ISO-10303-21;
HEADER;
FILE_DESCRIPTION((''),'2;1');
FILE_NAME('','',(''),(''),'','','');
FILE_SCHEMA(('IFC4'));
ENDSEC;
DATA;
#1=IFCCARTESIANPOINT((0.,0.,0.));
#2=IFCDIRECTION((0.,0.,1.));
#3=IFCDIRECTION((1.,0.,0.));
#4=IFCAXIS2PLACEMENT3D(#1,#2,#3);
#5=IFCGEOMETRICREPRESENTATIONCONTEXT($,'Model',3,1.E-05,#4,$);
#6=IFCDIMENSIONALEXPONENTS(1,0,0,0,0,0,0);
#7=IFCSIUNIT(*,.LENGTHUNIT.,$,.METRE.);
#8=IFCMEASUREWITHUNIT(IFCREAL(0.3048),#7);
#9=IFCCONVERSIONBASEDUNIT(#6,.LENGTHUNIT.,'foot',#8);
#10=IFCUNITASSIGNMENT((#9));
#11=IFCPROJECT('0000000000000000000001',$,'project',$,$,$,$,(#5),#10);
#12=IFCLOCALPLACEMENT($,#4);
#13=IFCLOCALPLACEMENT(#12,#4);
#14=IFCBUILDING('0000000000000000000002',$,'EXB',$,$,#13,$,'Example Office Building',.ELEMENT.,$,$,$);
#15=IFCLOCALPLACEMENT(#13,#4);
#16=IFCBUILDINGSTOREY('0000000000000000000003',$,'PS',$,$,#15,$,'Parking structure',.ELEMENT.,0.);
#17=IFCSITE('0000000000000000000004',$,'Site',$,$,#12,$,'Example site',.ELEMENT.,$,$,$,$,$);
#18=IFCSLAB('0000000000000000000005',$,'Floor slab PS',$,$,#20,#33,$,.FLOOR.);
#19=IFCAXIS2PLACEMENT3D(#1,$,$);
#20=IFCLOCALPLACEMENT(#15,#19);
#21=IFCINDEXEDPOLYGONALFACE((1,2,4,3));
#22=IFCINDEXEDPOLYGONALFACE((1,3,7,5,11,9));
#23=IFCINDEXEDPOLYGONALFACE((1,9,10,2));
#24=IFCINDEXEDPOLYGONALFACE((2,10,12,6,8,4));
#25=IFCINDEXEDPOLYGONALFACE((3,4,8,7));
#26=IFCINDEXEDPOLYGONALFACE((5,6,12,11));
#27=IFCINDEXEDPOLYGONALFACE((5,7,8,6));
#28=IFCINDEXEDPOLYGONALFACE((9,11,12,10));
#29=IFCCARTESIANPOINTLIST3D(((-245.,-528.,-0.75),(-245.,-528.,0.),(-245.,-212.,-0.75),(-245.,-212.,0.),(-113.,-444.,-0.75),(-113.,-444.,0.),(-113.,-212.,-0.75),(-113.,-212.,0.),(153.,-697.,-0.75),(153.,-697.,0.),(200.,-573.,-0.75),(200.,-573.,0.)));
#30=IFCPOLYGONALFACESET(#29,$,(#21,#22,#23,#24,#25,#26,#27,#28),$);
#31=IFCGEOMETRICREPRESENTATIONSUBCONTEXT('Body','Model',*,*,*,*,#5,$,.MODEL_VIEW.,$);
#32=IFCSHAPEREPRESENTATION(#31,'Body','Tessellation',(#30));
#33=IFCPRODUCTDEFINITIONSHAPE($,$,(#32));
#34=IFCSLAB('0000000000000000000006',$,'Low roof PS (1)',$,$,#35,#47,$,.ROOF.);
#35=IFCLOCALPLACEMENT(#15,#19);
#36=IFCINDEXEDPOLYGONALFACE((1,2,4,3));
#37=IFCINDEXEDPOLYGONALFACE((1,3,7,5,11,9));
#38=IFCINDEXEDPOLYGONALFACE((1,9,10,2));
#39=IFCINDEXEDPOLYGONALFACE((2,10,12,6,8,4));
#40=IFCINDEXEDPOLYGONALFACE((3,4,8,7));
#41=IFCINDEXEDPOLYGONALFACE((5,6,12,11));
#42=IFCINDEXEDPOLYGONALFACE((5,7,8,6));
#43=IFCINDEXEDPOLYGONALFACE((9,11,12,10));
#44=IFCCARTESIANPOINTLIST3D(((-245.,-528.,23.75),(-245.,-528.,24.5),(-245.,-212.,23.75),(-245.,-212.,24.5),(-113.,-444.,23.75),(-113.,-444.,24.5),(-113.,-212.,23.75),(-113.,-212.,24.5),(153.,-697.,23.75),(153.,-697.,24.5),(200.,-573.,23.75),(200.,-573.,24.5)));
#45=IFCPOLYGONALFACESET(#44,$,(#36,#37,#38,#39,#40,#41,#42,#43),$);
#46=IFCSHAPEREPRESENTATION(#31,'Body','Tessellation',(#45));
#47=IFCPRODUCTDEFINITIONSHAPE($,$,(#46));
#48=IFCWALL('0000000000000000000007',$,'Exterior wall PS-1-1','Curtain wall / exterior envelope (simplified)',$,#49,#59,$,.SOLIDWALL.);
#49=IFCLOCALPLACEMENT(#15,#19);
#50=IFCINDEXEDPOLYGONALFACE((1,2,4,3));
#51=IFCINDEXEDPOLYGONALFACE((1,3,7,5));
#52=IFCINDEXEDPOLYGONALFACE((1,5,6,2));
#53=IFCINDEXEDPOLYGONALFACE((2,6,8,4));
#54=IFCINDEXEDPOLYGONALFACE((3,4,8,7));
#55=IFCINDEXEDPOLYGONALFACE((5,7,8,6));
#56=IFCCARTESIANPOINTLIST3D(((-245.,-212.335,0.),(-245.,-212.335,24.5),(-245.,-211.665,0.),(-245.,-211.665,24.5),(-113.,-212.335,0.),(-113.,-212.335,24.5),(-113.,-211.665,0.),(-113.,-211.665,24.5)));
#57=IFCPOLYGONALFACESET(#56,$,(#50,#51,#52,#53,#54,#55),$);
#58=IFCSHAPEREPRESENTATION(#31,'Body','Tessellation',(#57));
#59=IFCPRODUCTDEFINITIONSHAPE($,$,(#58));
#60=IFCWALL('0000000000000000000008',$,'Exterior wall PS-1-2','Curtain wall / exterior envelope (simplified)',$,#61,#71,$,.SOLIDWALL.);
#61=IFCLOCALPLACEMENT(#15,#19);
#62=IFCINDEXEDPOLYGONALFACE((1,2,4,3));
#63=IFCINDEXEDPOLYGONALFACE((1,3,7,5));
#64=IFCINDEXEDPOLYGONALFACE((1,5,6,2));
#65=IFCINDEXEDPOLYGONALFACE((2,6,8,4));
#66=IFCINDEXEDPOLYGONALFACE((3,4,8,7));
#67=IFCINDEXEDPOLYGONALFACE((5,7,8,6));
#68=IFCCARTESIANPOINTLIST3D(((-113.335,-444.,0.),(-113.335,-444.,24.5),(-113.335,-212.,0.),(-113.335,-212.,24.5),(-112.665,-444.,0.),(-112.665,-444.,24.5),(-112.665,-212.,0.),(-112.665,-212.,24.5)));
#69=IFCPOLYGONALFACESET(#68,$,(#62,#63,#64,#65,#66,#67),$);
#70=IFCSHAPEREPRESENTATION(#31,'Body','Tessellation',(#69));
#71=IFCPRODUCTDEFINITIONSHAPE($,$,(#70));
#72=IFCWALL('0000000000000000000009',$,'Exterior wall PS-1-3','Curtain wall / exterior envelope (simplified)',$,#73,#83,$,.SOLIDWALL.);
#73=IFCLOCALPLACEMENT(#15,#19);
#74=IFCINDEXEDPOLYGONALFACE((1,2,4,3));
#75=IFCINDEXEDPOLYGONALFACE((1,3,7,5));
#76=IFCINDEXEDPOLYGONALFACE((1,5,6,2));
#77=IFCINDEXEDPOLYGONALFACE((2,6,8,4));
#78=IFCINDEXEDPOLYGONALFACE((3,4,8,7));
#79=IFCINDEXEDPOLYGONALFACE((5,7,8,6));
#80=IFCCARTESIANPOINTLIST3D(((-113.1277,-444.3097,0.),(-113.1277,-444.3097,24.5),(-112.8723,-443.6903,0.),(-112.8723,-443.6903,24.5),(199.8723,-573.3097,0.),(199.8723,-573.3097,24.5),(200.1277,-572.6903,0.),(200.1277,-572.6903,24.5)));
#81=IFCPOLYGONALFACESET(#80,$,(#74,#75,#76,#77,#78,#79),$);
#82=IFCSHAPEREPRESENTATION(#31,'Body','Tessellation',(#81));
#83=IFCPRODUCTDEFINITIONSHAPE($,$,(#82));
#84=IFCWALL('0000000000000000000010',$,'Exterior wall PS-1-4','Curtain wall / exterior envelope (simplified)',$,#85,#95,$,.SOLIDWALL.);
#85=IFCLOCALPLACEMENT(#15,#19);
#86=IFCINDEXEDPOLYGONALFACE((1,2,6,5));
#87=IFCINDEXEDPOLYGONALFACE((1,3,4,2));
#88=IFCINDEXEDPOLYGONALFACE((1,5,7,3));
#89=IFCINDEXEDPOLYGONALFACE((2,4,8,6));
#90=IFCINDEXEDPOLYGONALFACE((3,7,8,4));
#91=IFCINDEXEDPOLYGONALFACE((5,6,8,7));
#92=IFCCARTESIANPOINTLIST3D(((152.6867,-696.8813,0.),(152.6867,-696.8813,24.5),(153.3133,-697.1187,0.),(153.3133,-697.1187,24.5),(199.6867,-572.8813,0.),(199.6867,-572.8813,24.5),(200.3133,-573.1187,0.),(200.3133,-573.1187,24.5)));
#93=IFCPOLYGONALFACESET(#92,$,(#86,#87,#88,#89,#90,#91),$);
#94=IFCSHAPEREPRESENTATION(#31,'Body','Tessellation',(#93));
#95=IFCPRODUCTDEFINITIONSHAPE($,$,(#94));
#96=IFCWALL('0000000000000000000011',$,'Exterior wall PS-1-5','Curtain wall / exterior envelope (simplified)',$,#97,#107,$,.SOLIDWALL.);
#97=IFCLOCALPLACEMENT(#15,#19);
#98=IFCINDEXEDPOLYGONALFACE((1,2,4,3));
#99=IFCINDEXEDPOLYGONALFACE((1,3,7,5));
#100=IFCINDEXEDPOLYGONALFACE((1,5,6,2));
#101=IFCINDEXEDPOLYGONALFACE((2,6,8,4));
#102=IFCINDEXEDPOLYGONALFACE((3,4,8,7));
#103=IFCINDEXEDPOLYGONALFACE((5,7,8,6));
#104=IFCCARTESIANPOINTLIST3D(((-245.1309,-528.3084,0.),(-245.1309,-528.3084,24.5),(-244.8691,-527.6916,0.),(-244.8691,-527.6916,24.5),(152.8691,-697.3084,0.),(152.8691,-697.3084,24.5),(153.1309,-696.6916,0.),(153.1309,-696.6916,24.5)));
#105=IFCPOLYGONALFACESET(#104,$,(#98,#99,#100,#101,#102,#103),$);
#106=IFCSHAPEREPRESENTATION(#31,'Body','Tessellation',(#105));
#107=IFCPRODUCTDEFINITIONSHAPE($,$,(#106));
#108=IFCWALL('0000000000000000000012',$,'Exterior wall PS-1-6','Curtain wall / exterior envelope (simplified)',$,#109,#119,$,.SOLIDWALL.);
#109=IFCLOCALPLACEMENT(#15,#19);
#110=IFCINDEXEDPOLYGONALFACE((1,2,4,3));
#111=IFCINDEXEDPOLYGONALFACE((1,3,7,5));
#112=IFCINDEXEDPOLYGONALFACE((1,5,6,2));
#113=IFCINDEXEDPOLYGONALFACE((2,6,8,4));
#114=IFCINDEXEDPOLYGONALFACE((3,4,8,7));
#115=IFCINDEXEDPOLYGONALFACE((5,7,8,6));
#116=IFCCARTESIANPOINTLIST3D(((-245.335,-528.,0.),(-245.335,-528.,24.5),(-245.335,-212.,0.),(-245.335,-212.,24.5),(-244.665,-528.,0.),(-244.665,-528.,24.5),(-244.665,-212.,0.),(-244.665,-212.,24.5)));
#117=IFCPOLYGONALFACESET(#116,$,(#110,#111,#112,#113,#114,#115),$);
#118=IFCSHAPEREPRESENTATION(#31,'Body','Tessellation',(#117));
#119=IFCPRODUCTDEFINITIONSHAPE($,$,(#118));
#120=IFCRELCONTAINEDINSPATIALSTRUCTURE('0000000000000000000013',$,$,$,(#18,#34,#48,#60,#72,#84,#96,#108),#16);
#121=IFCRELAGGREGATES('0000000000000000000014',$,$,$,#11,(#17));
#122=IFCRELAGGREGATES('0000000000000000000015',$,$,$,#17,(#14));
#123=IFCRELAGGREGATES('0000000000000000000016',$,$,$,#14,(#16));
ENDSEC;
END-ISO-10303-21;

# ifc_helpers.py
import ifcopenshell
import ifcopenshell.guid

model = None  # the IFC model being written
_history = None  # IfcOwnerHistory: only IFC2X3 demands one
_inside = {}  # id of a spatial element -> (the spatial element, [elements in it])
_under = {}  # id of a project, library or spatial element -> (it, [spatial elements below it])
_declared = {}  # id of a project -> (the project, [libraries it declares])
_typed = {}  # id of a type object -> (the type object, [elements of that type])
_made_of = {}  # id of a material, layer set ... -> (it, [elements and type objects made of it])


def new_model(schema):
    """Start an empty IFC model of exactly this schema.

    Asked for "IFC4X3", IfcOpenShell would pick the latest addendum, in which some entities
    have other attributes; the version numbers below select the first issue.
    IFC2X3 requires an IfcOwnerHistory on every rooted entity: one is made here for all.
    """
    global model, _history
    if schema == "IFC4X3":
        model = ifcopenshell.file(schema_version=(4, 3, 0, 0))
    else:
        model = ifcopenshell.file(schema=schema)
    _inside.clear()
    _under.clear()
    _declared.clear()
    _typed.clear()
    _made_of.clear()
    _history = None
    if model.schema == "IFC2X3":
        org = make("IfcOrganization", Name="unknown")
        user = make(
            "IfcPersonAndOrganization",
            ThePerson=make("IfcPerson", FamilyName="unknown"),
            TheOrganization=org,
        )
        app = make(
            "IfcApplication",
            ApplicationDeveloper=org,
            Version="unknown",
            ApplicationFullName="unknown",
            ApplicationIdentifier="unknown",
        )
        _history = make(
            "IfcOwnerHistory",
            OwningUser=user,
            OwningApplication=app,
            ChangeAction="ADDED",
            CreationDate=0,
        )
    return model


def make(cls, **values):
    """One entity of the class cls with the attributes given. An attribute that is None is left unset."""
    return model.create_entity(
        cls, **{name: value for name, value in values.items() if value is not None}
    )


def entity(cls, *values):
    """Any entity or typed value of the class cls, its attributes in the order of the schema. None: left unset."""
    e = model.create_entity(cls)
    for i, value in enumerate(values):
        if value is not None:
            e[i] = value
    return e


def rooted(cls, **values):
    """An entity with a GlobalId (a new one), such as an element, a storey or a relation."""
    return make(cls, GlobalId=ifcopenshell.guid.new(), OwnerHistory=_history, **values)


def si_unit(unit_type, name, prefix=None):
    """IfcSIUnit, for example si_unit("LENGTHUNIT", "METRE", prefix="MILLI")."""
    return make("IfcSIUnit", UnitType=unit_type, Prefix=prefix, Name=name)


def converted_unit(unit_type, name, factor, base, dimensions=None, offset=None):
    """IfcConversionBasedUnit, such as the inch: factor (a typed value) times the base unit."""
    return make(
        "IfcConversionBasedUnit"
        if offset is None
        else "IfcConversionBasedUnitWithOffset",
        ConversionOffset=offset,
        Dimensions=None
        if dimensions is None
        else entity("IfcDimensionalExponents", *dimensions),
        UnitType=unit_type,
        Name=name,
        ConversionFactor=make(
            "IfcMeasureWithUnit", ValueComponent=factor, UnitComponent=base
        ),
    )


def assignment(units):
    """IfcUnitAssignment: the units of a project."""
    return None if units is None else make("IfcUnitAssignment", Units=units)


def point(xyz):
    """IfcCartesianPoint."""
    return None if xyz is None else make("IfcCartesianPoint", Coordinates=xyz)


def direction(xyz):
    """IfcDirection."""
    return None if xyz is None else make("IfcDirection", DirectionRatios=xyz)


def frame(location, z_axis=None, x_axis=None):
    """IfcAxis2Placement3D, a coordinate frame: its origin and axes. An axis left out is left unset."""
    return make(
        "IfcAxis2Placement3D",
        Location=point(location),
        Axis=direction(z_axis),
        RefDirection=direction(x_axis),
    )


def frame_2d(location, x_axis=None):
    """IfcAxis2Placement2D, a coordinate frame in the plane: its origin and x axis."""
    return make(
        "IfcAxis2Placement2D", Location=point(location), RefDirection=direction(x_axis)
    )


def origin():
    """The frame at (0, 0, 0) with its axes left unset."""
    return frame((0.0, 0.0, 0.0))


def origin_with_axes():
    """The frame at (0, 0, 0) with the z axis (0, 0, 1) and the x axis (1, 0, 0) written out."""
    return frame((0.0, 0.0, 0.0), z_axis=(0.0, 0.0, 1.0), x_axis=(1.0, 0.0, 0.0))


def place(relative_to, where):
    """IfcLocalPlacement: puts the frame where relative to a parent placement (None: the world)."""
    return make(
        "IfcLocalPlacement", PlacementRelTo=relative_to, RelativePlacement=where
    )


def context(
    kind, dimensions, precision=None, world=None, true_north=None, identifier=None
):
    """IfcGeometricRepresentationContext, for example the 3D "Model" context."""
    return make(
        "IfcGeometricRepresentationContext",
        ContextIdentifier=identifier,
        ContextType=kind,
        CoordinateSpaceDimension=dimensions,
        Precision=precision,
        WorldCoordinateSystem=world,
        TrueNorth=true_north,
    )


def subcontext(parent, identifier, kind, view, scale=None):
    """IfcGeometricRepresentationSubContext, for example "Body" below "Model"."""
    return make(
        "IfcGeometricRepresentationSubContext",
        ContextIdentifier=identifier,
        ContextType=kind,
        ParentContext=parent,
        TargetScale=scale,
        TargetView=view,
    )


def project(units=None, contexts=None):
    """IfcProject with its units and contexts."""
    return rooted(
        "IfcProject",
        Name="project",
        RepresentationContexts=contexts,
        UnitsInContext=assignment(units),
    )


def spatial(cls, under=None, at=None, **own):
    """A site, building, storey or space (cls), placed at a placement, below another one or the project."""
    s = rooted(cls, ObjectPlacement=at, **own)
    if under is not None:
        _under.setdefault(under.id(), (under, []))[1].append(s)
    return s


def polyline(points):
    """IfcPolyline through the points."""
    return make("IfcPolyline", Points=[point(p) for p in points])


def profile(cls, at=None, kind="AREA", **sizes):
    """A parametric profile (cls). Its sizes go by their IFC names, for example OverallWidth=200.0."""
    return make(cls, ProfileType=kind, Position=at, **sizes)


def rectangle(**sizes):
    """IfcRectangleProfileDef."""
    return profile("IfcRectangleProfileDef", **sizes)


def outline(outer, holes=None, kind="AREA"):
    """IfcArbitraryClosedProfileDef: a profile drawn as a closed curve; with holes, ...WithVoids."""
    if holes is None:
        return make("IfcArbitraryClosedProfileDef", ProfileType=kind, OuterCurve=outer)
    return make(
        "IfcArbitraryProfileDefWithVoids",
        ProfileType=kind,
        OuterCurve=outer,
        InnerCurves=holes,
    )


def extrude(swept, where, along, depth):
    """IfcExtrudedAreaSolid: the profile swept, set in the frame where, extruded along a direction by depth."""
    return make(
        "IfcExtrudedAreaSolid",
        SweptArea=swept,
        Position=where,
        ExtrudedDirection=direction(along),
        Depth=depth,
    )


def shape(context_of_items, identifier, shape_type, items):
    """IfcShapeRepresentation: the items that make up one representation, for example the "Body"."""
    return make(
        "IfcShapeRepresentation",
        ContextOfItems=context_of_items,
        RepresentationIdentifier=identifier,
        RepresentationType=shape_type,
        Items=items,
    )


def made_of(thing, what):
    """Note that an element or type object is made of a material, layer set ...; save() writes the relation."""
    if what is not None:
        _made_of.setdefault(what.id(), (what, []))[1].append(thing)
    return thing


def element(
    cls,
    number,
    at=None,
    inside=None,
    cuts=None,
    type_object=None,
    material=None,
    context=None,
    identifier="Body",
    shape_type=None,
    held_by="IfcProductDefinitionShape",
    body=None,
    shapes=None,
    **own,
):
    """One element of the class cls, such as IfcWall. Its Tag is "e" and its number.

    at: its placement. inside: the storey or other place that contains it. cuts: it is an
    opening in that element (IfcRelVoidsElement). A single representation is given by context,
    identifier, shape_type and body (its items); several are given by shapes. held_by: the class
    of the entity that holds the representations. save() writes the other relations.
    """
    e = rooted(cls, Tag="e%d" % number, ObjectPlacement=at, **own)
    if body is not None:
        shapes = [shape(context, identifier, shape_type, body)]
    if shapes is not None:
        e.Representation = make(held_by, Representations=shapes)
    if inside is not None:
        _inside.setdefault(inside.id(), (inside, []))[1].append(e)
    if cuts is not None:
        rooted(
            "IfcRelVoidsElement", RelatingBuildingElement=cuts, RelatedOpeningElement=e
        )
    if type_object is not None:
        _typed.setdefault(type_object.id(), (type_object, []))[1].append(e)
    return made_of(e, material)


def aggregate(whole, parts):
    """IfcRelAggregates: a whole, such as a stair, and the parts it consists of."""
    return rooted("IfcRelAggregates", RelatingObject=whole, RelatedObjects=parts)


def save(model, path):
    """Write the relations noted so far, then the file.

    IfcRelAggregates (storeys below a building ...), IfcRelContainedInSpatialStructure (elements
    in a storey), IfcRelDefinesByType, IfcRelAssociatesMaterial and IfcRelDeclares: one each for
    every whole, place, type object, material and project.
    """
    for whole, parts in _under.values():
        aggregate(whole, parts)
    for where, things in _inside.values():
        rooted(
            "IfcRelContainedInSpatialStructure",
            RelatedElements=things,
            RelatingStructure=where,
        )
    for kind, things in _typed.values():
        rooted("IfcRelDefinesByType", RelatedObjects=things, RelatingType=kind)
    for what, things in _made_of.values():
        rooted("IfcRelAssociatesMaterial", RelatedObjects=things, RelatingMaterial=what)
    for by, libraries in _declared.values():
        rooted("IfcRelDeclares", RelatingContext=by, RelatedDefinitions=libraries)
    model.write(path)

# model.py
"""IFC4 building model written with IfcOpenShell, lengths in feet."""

from ifc_helpers import new_model, entity, si_unit, converted_unit, frame, frame_2d, origin, origin_with_axes, place, context, subcontext, project, spatial, polyline, rectangle, outline, extrude, element, save


model = new_model("IFC4")

# Units and contexts
model_context = context("Model", 3, precision=1e-05, world=origin_with_axes())
body_context = subcontext(model_context, "Body", "Model", "MODEL_VIEW")
ifc_project = project(units=[converted_unit("LENGTHUNIT", "foot", entity("IfcReal", 0.3048), si_unit("LENGTHUNIT", "METRE"), dimensions=[1, 0, 0, 0, 0, 0, 0])], contexts=[model_context])

# Site, building, storey
site_placement = place(None, origin_with_axes())
site = spatial("IfcSite", under=ifc_project, at=site_placement, Name="Site", LongName="Example site", CompositionType="ELEMENT")
building_placement = place(site_placement, origin_with_axes())
building = spatial("IfcBuilding", under=site, at=building_placement, Name="EXB", LongName="Example Office Building", CompositionType="ELEMENT")
storey_placement = place(building_placement, origin_with_axes())
storey = spatial("IfcBuildingStorey", under=building, at=storey_placement, Name="PS", LongName="Parking structure", CompositionType="ELEMENT", Elevation=0.0)

# Slabs
slab_1_placement = place(storey_placement, origin_with_axes())
element("IfcSlab", 1, at=slab_1_placement, inside=storey, Name="Floor slab PS", PredefinedType="FLOOR", context=body_context, shape_type="SweptSolid", body=[
    extrude(outline(polyline([(-245.0, -212.0), (-113.0, -212.0), (-113.0, -444.0), (200.0, -573.0), (153.0, -697.0), (-245.0, -528.0), (-245.0, -212.0)])), frame((0.0, 0.0, -0.75)), (0.0, 0.0, 1.0), 0.75),
])
slab_2_placement = place(storey_placement, origin_with_axes())
element("IfcSlab", 2, at=slab_2_placement, inside=storey, Name="Low roof PS (1)", PredefinedType="ROOF", context=body_context, shape_type="SweptSolid", body=[
    extrude(outline(polyline([(-245.0, -212.0), (-113.0, -212.0), (-113.0, -444.0), (200.0, -573.0), (153.0, -697.0), (-245.0, -528.0), (-245.0, -212.0)])), frame((0.0, 0.0, 23.75)), (0.0, 0.0, 1.0), 0.75),
])

# Walls
wall_1_placement = place(storey_placement, frame((-245.0, -212.0, 0.0), z_axis=(0.0, 0.0, 1.0), x_axis=(1.0, 0.0, 0.0)))
element("IfcWall", 3, at=wall_1_placement, inside=storey, Name="Exterior wall PS-1-1", Description="Curtain wall / exterior envelope (simplified)", PredefinedType="SOLIDWALL", context=body_context, shape_type="SweptSolid", body=[
    extrude(rectangle(XDim=132.0, YDim=0.67, at=frame_2d((66.0, 0.0))), origin(), (0.0, 0.0, 1.0), 24.5),
])
wall_2_placement = place(storey_placement, frame((-113.0, -212.0, 0.0), z_axis=(0.0, 0.0, 1.0), x_axis=(0.0, -1.0, 0.0)))
element("IfcWall", 4, at=wall_2_placement, inside=storey, Name="Exterior wall PS-1-2", Description="Curtain wall / exterior envelope (simplified)", PredefinedType="SOLIDWALL", context=body_context, shape_type="SweptSolid", body=[
    extrude(rectangle(XDim=232.0, YDim=0.67, at=frame_2d((116.0, 0.0))), origin(), (0.0, 0.0, 1.0), 24.5),
])
wall_3_placement = place(storey_placement, frame((-113.0, -444.0, 0.0), z_axis=(0.0, 0.0, 1.0), x_axis=(0.924556, -0.381047, 0.0)))
element("IfcWall", 5, at=wall_3_placement, inside=storey, Name="Exterior wall PS-1-3", Description="Curtain wall / exterior envelope (simplified)", PredefinedType="SOLIDWALL", context=body_context, shape_type="SweptSolid", body=[
    extrude(rectangle(XDim=338.541, YDim=0.67, at=frame_2d((169.2705, 0.0))), origin(), (0.0, 0.0, 1.0), 24.5),
])
wall_4_placement = place(storey_placement, frame((200.0, -573.0, 0.0), z_axis=(0.0, 0.0, 1.0), x_axis=(-0.354427, -0.935084, 0.0)))
element("IfcWall", 6, at=wall_4_placement, inside=storey, Name="Exterior wall PS-1-4", Description="Curtain wall / exterior envelope (simplified)", PredefinedType="SOLIDWALL", context=body_context, shape_type="SweptSolid", body=[
    extrude(rectangle(XDim=132.6084, YDim=0.67, at=frame_2d((66.3042, 0.0))), origin(), (0.0, 0.0, 1.0), 24.5),
])
wall_5_placement = place(storey_placement, frame((153.0, -697.0, 0.0), z_axis=(0.0, 0.0, 1.0), x_axis=(-0.920456, 0.390847, 0.0)))
element("IfcWall", 7, at=wall_5_placement, inside=storey, Name="Exterior wall PS-1-5", Description="Curtain wall / exterior envelope (simplified)", PredefinedType="SOLIDWALL", context=body_context, shape_type="SweptSolid", body=[
    extrude(rectangle(XDim=432.3945, YDim=0.67, at=frame_2d((216.1972, 0.0))), origin(), (0.0, 0.0, 1.0), 24.5),
])
wall_6_placement = place(storey_placement, frame((-245.0, -528.0, 0.0), z_axis=(0.0, 0.0, 1.0), x_axis=(0.0, 1.0, 0.0)))
element("IfcWall", 8, at=wall_6_placement, inside=storey, Name="Exterior wall PS-1-6", Description="Curtain wall / exterior envelope (simplified)", PredefinedType="SOLIDWALL", context=body_context, shape_type="SweptSolid", body=[
    extrude(rectangle(XDim=316.0, YDim=0.67, at=frame_2d((158.0, 0.0))), origin(), (0.0, 0.0, 1.0), 24.5),
])

save(model, "model.ifc")
